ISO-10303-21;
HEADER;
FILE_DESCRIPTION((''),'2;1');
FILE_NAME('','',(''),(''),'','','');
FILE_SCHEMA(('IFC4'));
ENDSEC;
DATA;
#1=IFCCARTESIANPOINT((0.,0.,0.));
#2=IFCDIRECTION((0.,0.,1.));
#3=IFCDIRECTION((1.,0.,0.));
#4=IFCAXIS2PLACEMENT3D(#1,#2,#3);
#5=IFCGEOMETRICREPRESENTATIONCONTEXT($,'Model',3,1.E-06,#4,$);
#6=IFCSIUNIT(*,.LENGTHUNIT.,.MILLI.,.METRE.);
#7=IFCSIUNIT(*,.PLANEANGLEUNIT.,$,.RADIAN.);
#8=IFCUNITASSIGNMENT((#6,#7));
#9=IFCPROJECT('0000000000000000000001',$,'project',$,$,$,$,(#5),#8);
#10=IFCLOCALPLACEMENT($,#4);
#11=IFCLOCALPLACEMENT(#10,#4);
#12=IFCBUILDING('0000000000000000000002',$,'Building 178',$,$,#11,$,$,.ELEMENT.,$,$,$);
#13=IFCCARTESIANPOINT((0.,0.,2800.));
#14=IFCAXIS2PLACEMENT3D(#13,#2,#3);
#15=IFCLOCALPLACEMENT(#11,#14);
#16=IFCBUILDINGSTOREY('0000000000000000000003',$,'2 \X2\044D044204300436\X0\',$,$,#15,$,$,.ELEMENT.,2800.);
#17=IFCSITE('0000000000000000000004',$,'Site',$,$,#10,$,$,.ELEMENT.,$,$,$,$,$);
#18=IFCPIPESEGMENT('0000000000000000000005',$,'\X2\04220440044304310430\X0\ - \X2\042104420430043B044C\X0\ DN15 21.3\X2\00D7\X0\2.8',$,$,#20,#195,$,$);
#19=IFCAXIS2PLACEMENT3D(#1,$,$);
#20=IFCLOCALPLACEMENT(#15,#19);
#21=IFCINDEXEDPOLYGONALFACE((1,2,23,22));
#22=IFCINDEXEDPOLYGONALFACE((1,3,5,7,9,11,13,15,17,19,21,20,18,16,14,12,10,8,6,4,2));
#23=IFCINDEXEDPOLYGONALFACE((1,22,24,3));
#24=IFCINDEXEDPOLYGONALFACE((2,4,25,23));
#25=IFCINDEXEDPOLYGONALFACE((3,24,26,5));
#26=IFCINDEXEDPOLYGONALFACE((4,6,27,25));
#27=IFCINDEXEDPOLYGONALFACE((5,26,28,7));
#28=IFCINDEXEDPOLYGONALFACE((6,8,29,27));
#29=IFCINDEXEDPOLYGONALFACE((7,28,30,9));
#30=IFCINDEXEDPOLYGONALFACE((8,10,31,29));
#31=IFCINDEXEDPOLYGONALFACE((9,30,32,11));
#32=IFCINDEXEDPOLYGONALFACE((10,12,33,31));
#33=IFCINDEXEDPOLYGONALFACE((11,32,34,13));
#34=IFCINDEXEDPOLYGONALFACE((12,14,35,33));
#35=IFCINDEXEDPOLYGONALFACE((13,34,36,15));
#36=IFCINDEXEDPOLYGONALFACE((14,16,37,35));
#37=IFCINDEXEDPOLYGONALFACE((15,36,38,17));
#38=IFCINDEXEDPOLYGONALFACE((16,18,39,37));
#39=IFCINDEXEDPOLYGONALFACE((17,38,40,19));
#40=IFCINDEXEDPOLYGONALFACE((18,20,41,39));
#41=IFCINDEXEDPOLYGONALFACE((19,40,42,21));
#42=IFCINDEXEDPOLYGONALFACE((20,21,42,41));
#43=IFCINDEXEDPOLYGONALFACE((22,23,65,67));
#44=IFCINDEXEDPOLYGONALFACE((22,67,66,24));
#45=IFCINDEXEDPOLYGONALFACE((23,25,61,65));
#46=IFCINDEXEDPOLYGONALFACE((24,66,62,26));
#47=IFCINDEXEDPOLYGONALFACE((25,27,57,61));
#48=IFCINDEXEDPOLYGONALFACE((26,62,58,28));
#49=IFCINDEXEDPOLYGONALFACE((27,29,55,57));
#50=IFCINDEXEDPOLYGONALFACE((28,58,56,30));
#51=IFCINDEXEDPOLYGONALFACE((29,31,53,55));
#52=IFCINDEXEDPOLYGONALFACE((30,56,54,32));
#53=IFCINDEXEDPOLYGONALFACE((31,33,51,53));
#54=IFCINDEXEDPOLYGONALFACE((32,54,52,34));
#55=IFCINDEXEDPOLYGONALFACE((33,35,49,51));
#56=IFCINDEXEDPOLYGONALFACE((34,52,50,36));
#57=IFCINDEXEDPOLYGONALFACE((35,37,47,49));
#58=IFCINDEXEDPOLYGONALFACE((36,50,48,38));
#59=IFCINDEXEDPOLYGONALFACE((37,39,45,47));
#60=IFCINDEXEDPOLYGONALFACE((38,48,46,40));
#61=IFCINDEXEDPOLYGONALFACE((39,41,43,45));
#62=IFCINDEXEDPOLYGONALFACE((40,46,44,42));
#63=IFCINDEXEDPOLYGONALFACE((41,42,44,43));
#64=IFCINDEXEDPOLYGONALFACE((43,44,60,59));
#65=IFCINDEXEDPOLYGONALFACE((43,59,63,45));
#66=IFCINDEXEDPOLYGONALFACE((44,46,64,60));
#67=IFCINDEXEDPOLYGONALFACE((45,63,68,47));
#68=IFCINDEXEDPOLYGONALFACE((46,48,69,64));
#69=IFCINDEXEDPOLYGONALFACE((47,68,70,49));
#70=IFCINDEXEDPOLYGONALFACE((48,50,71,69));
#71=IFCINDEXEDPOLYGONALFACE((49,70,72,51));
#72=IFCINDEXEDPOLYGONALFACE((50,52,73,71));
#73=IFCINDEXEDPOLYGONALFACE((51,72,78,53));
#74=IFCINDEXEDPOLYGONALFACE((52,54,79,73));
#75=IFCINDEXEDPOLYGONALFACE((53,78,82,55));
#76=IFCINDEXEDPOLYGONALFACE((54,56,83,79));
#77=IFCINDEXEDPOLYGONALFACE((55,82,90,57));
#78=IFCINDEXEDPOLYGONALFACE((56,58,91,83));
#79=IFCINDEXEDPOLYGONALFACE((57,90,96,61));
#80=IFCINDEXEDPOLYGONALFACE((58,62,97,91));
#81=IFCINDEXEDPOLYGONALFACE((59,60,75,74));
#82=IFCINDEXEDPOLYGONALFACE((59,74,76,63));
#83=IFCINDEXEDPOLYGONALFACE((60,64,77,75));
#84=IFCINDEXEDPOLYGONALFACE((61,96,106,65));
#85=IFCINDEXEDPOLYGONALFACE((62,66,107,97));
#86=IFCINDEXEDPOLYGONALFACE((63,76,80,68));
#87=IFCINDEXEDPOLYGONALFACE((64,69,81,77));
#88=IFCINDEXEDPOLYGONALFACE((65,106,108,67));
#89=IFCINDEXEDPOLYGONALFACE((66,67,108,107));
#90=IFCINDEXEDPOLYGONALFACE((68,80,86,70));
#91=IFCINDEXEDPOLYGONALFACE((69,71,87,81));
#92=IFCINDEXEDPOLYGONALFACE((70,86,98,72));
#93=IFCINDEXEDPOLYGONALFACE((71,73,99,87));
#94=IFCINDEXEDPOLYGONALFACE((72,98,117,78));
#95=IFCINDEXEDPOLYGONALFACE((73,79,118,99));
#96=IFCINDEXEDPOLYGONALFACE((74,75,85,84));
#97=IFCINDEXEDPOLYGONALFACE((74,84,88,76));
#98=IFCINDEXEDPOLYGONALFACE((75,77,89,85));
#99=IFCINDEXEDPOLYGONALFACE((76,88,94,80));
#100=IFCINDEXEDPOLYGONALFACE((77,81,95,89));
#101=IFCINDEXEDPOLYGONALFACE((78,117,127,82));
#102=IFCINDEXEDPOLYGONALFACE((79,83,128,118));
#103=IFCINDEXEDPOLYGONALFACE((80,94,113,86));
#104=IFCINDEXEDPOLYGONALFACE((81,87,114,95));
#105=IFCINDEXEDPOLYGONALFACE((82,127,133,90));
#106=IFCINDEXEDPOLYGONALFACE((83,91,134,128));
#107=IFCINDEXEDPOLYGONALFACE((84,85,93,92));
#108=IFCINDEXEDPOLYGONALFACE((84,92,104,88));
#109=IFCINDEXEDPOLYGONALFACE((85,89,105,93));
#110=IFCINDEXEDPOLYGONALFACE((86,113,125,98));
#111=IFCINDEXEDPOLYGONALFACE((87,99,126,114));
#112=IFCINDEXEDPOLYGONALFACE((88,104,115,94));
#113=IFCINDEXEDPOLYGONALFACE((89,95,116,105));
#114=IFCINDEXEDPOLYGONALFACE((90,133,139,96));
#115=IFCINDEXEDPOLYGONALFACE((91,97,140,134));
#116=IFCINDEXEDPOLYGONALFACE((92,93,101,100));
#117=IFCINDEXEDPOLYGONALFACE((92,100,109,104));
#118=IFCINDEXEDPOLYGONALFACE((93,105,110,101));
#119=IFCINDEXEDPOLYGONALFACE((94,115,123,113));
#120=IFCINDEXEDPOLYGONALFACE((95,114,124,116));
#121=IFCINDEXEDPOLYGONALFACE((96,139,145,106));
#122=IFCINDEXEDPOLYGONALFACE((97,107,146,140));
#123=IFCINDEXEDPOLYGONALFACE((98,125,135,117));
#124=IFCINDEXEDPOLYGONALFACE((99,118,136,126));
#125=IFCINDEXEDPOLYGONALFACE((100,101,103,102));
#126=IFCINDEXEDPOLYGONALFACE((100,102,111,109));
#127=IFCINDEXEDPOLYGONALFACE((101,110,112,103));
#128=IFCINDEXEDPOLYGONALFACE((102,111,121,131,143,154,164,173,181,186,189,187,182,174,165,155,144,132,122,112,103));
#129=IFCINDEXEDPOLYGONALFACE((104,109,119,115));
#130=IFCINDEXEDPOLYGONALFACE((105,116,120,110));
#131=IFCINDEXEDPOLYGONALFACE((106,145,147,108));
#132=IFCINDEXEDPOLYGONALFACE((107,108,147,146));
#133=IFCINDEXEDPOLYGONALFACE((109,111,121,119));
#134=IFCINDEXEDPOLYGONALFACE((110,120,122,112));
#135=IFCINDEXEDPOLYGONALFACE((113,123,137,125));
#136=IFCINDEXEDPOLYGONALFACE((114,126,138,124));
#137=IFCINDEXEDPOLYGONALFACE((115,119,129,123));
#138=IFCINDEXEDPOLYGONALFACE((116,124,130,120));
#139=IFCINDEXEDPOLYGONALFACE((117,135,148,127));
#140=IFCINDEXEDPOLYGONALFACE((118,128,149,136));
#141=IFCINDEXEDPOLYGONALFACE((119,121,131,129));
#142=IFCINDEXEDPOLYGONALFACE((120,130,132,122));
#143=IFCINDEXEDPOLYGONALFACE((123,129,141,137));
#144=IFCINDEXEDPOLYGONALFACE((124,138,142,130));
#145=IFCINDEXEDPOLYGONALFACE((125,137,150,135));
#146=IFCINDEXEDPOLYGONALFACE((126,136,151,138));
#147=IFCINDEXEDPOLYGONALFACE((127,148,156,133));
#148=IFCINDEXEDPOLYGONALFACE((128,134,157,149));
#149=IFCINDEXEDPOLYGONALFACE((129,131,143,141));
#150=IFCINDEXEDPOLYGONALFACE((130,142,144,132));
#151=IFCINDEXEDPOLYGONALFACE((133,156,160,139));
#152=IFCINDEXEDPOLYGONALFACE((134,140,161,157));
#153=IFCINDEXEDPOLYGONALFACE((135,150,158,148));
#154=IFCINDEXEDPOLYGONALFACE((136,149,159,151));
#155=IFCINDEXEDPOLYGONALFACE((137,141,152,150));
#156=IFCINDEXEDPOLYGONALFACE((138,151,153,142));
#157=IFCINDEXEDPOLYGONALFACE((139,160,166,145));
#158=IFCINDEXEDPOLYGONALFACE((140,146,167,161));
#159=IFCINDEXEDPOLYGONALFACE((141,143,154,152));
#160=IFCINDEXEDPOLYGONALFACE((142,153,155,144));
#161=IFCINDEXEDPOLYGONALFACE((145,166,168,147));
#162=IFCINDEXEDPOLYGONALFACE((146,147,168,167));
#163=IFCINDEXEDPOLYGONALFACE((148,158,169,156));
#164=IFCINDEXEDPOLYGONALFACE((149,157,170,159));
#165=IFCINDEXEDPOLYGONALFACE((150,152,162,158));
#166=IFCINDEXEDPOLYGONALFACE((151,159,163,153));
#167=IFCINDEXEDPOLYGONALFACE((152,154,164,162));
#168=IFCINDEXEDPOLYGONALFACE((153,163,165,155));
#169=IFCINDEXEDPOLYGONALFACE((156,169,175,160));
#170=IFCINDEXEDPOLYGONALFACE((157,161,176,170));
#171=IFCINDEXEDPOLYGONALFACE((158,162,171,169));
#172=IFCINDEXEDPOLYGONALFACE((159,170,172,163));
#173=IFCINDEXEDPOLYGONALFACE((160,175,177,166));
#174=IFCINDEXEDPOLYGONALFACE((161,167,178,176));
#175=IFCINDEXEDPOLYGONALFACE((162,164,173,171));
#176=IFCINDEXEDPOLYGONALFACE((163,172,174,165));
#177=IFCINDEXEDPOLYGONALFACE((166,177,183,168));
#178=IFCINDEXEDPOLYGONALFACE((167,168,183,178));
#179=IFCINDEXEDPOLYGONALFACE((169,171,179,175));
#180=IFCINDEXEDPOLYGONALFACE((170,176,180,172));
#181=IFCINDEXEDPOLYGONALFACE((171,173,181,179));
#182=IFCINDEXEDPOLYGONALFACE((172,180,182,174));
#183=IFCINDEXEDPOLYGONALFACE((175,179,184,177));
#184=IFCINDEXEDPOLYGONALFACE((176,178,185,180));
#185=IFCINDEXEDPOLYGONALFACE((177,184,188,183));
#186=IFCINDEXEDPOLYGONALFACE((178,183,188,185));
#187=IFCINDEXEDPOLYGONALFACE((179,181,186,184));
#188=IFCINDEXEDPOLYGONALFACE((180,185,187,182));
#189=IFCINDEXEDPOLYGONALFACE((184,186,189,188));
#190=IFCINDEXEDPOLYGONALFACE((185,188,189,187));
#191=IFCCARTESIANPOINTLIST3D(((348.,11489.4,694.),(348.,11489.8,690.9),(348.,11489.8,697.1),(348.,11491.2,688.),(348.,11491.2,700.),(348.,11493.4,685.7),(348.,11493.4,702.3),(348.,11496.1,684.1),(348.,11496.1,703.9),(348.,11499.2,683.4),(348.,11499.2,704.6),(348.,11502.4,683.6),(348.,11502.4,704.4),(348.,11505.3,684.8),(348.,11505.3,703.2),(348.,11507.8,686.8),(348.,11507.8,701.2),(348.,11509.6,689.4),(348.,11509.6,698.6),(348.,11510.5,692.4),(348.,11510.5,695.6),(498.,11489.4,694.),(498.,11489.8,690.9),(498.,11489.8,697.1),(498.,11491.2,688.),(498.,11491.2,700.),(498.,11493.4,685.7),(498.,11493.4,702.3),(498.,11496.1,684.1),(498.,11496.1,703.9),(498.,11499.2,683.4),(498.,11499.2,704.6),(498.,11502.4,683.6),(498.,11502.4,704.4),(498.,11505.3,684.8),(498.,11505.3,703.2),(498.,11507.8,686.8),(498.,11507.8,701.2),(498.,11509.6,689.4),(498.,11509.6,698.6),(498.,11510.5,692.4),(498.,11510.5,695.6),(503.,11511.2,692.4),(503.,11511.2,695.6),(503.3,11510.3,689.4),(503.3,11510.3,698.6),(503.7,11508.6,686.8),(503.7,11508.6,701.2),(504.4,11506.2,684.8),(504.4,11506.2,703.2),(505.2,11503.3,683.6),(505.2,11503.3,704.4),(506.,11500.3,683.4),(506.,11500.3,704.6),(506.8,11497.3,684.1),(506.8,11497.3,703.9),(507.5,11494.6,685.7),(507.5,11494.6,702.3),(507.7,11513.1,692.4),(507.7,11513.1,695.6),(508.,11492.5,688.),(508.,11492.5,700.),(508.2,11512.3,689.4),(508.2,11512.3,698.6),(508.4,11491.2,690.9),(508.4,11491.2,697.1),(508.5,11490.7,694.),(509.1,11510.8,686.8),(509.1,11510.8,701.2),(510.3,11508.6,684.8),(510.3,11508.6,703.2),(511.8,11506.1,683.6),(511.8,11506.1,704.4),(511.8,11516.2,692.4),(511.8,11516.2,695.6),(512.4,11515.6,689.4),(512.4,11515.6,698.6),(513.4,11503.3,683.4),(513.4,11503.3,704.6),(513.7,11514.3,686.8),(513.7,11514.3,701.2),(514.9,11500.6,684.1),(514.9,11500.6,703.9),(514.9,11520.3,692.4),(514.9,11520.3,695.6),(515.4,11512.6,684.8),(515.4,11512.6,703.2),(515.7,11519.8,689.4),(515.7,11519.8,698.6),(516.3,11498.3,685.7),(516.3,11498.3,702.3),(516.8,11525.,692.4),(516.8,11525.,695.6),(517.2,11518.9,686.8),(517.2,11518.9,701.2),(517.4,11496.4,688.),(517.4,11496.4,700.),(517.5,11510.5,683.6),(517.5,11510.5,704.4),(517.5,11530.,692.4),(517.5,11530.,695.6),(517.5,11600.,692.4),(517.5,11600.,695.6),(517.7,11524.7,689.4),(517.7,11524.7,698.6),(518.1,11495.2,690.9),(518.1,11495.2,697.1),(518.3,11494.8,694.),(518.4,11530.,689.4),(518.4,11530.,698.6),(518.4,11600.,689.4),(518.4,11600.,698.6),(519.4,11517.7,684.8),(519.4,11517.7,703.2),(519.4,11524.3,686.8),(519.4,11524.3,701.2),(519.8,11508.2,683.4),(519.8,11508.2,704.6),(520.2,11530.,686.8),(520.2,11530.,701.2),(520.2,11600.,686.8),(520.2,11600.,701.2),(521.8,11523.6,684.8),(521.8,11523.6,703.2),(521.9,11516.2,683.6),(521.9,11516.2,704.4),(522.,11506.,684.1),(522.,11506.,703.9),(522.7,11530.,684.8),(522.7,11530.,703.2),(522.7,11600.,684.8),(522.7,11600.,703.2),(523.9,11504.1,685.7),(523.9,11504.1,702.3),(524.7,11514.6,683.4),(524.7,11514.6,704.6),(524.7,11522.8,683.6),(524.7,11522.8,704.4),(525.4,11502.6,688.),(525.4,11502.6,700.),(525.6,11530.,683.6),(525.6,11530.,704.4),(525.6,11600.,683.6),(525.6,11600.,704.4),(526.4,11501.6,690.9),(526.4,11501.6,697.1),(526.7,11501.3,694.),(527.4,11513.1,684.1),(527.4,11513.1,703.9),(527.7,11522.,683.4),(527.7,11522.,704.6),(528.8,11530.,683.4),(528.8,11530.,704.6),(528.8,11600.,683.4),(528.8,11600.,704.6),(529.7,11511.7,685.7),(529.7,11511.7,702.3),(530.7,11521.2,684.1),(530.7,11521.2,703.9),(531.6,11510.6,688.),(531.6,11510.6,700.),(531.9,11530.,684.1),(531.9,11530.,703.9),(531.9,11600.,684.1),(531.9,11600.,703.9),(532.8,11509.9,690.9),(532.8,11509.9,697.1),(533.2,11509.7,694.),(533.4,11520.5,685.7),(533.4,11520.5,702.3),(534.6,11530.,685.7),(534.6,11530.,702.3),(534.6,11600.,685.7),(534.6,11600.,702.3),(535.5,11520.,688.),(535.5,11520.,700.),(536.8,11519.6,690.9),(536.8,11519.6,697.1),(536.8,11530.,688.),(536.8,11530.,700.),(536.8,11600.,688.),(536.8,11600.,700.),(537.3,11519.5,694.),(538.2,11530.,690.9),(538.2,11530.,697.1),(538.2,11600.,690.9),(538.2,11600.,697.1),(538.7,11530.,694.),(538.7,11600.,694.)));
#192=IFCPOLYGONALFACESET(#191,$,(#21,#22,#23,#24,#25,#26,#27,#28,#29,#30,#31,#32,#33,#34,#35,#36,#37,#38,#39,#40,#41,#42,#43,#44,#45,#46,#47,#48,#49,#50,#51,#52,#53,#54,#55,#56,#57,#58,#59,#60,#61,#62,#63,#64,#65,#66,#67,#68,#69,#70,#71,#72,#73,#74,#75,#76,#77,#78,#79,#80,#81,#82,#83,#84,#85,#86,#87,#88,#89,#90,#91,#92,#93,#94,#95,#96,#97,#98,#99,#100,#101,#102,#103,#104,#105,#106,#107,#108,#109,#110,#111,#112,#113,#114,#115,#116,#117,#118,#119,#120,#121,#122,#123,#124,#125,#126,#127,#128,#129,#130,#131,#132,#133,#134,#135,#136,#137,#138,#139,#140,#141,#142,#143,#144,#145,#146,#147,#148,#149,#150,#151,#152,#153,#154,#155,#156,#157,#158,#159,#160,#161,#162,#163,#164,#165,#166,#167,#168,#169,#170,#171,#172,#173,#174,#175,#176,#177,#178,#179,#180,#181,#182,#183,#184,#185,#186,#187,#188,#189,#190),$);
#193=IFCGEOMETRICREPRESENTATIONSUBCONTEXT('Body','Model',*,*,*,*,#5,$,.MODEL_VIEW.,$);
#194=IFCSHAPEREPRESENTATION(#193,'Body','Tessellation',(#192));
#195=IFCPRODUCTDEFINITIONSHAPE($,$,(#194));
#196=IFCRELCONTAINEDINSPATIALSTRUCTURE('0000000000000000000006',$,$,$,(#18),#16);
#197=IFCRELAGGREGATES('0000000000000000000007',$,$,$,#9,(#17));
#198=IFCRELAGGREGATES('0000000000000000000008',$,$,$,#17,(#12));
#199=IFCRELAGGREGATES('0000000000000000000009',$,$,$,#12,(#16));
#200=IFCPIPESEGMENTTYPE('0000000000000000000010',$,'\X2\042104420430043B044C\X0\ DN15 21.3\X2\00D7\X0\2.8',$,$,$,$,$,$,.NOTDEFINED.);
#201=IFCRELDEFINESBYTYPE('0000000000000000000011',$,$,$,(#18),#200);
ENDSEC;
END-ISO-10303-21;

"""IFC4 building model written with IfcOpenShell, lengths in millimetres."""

from ifc_helpers import new_model, entity, si_unit, frame, origin_with_axes, place, context, subcontext, project, spatial, source, transform, mapped, type_object, element, save


model = new_model("IFC4")

# Units and contexts
model_context = context("Model", 3, precision=1e-06, world=origin_with_axes())
body_context = subcontext(model_context, "Body", "Model", "MODEL_VIEW")
ifc_project = project(units=[si_unit("LENGTHUNIT", "METRE", prefix="MILLI"), si_unit("PLANEANGLEUNIT", "RADIAN")], contexts=[model_context])

# Site, building, storey
site_placement = place(None, origin_with_axes())
site = spatial("IfcSite", under=ifc_project, at=site_placement, Name="Site", CompositionType="ELEMENT")
building_placement = place(site_placement, origin_with_axes())
building = spatial("IfcBuilding", under=site, at=building_placement, Name="Building 178", CompositionType="ELEMENT")
storey_placement = place(building_placement, frame((0.0, 0.0, 2800.0), z_axis=(0.0, 0.0, 1.0), x_axis=(1.0, 0.0, 0.0)))
storey = spatial("IfcBuildingStorey", under=building, at=storey_placement, Name="2 этаж", CompositionType="ELEMENT", Elevation=2800.0)

# Pipe segment
pipe_segment_type = type_object("IfcPipeSegmentType", Name="Сталь DN15 21.3×2.8", PredefinedType="NOTDEFINED")
shared_shape_1 = source(origin_with_axes(), body_context, "Body", "AdvancedSweptSolid", [
    entity("IfcSweptDiskSolid", entity("IfcIndexedPolyCurve", entity("IfcCartesianPointList3D", [[0.0, 0.0, 0.0], [0.0, 0.0, -70.0], [8.8, 0.0, -91.2], [30.0, 0.0, -100.0], [180.0, 0.0, -100.0]]), [entity("IfcLineIndex", [1, 2]), entity("IfcArcIndex", [2, 3, 4]), entity("IfcLineIndex", [4, 5])]), 10.7),
])
for number, where, z_axis, x_axis, name in (
    (1, (528.0, 11600.0, 694.0), (0.0, 1.0, 0.0), (-1.0, 0.0, 0.0), "Труба - Сталь DN15 21.3×2.8"),
):
    element("IfcPipeSegment", number, at=place(storey_placement, frame(where, z_axis=z_axis, x_axis=x_axis)), inside=storey, type_object=pipe_segment_type, Name=name, context=body_context, shape_type="MappedRepresentation", body=[
        mapped(shared_shape_1, transform((0.0, 0.0, 0.0), x_axis=(1.0, 0.0, 0.0), y_axis=(0.0, 1.0, 0.0), z_axis=(0.0, 0.0, 1.0), scale=1.0)),
    ])

save(model, "model.ifc")
